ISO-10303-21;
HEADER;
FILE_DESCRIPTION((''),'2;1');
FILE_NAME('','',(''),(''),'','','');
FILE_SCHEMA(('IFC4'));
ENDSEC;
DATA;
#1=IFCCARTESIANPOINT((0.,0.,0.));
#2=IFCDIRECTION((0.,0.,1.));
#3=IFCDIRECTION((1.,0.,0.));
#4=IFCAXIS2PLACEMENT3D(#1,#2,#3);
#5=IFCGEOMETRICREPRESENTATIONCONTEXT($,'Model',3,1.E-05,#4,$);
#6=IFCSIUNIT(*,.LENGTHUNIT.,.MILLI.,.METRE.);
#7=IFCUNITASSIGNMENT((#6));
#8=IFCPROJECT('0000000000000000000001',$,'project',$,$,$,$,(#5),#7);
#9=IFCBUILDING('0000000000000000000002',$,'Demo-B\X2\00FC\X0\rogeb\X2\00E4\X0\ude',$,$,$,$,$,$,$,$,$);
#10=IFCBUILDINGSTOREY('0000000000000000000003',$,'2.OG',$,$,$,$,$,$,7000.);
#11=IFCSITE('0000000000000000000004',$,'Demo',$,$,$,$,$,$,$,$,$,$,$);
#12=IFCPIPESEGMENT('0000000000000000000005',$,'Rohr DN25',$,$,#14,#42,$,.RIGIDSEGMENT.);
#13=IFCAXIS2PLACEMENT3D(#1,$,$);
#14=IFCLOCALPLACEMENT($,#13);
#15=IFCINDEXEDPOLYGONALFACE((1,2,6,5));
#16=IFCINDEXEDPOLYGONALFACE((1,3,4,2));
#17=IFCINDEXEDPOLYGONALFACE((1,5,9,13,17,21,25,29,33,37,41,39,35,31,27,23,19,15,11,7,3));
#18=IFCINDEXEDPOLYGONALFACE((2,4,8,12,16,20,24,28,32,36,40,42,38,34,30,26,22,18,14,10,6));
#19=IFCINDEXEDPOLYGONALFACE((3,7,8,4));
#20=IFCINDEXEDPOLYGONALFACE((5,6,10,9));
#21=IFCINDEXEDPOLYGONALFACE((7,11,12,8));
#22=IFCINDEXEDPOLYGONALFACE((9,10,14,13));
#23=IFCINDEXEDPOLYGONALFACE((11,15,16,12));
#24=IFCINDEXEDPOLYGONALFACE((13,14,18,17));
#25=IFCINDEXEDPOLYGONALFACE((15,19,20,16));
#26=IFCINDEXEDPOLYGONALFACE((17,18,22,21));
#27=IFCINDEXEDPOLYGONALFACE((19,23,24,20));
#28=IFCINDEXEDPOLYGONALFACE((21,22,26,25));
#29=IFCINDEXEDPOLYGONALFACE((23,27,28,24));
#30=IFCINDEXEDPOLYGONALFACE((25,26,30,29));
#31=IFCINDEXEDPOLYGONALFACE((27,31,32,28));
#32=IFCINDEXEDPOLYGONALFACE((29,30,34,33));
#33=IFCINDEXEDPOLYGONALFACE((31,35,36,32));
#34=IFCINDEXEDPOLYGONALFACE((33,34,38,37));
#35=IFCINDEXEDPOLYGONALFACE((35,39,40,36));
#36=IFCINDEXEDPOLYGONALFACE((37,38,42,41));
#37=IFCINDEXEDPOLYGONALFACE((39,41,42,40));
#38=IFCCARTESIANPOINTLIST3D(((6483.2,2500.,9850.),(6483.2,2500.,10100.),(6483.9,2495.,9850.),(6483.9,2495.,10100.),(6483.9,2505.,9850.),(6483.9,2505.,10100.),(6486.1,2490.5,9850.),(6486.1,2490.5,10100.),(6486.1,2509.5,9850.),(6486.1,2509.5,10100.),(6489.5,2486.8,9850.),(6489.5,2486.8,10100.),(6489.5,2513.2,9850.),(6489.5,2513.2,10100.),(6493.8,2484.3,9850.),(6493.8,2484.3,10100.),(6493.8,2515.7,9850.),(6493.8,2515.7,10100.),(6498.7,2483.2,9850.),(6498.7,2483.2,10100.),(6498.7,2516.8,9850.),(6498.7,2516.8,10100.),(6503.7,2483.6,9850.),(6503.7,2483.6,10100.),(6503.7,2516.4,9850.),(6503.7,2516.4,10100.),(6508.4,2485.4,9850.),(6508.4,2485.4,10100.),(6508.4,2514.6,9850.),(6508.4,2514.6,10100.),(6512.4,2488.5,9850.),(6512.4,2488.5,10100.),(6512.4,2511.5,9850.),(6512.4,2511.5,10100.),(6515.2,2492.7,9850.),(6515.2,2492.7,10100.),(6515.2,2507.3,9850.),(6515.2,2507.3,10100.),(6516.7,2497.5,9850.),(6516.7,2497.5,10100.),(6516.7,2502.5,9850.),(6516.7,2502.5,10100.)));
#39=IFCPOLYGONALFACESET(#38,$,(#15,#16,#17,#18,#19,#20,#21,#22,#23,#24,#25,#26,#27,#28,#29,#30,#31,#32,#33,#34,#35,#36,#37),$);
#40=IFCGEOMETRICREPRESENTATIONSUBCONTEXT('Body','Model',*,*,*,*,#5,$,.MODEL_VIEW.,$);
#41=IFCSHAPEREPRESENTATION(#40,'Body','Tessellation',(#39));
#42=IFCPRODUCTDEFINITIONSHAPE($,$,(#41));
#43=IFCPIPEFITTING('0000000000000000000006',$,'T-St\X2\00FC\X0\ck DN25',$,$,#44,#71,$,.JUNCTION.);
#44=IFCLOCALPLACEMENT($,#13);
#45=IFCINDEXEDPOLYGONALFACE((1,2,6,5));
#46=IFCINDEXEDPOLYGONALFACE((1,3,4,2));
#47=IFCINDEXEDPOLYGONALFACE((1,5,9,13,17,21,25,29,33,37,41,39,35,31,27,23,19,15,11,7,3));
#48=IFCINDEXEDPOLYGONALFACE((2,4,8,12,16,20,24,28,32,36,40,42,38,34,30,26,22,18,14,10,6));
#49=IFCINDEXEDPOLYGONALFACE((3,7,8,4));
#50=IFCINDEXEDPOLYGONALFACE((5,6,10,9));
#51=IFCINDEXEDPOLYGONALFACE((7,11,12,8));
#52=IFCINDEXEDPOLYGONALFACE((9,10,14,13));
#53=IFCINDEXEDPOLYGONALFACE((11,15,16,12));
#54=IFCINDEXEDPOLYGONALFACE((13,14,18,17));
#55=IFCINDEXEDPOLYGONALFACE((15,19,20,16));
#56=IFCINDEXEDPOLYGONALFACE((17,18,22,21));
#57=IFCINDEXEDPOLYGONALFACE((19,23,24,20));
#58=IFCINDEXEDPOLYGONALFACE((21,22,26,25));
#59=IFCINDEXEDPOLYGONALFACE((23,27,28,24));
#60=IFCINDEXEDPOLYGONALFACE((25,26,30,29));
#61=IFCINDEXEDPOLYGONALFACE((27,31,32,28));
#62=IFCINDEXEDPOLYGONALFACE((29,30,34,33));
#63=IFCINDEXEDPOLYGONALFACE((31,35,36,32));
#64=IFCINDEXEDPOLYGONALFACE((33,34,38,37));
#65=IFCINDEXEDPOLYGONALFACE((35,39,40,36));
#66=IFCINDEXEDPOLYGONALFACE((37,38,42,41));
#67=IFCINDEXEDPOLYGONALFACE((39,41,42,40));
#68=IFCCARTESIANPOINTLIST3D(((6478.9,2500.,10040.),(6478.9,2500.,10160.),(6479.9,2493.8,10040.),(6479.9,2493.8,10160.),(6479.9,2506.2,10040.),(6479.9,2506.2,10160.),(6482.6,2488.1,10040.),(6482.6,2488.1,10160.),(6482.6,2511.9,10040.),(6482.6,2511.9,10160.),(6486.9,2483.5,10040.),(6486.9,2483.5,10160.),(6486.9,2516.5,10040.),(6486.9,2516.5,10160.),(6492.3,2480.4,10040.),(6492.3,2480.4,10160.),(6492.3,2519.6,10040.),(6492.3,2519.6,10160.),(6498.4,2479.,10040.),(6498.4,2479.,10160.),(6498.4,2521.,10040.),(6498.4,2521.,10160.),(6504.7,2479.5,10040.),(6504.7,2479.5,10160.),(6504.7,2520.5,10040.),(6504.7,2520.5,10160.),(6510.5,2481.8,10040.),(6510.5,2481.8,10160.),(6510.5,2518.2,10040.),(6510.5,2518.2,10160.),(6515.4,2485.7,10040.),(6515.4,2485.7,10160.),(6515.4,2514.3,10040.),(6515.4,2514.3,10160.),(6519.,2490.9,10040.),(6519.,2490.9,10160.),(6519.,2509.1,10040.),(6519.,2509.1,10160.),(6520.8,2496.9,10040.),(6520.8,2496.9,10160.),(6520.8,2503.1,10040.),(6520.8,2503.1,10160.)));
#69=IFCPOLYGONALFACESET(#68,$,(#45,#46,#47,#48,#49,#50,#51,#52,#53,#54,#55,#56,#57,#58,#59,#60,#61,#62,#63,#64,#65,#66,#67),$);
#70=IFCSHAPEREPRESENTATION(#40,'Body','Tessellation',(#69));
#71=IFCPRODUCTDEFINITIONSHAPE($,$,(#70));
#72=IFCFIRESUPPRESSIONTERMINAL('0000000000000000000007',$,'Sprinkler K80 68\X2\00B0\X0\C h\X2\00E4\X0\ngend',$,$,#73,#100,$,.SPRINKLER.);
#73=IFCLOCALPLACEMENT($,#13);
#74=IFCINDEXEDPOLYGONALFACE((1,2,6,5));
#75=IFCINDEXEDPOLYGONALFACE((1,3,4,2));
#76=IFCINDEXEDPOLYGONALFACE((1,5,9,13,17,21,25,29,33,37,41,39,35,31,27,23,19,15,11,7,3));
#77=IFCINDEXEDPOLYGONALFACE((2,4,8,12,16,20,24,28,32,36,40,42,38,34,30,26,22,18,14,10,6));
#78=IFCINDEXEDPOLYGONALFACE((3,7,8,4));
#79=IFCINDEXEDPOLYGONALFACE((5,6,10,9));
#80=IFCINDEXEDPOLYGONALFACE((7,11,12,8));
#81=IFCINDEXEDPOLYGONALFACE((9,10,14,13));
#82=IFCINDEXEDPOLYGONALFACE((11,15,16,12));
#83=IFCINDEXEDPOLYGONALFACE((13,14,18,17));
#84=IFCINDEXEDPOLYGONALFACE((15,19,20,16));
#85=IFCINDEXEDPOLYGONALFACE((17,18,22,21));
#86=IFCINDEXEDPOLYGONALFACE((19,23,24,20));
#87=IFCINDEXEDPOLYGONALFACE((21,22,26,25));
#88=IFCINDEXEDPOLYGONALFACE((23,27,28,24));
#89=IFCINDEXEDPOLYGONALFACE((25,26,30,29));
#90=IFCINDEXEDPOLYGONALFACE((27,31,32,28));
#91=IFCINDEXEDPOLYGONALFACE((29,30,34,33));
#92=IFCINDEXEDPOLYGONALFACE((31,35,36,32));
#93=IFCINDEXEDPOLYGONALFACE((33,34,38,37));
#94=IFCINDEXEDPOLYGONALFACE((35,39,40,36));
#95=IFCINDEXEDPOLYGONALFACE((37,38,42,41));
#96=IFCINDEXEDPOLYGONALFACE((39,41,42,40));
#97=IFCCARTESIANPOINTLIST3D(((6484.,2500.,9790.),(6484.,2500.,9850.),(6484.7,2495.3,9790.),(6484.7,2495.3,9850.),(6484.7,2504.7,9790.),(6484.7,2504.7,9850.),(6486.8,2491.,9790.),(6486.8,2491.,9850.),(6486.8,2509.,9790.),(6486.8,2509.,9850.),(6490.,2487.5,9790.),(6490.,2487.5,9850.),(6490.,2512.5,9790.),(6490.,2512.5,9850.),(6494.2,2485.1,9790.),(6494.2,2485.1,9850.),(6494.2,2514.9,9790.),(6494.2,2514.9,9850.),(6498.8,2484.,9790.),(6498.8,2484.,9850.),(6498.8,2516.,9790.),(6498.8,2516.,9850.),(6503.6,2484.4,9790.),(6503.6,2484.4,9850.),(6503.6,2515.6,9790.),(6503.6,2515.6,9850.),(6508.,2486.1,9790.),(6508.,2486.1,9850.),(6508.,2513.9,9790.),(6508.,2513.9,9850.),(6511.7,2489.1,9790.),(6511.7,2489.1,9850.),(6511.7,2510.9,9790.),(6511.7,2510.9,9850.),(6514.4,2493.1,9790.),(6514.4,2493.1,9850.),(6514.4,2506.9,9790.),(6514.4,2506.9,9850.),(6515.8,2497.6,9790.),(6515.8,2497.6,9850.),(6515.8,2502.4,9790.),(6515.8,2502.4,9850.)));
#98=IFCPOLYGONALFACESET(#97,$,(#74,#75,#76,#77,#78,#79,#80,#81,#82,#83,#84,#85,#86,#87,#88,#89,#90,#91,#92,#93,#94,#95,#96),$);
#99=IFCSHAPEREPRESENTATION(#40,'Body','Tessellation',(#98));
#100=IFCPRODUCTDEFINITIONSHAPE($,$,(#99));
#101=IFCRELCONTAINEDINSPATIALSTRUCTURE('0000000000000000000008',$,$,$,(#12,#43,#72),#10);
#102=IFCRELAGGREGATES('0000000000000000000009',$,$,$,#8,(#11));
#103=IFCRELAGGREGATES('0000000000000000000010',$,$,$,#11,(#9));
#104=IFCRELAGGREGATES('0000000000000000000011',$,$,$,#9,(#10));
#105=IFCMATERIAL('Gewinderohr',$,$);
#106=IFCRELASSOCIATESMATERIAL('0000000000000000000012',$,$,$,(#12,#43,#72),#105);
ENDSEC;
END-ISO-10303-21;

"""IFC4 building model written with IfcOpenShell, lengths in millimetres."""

from ifc_helpers import new_model, si_unit, frame, origin_with_axes, place, context, subcontext, project, spatial, circle, extrude, material, element, save


model = new_model("IFC4")

# Units and contexts
model_context = context("Model", 3, precision=1e-05, world=origin_with_axes())
body_context = subcontext(model_context, "Body", "Model", "MODEL_VIEW")
ifc_project = project(units=[si_unit("LENGTHUNIT", "METRE", prefix="MILLI")], contexts=[model_context])

# Site, building, storey
site = spatial("IfcSite", under=ifc_project, Name="Demo")
building = spatial("IfcBuilding", under=site, Name="Demo-Bürogebäude")
storey = spatial("IfcBuildingStorey", under=building, Name="2.OG", Elevation=7000.0)

# Shared definitions
ifc_material_1 = material(Name="Gewinderohr")

# Pipe segment
pipe_segment_1_placement = place(None, frame((6500.0, 2500.0, 10100.0), z_axis=(0.0, 0.0, -1.0), x_axis=(-1.0, 0.0, 0.0)))
element("IfcPipeSegment", 1, at=pipe_segment_1_placement, inside=storey, material=ifc_material_1, Name="Rohr DN25", PredefinedType="RIGIDSEGMENT", context=body_context, shape_type="SweptSolid", body=[
    extrude(circle(Radius=16.9), origin_with_axes(), (0.0, 0.0, 1.0), 250.0),
])

# Pipe fitting
pipe_fitting_1_placement = place(None, frame((6500.0, 2500.0, 10160.0), z_axis=(0.0, 0.0, -1.0), x_axis=(-1.0, 0.0, 0.0)))
element("IfcPipeFitting", 2, at=pipe_fitting_1_placement, inside=storey, material=ifc_material_1, Name="T-Stück DN25", PredefinedType="JUNCTION", context=body_context, shape_type="SweptSolid", body=[
    extrude(circle(Radius=21.1), origin_with_axes(), (0.0, 0.0, 1.0), 120.0),
])

# Fire suppression terminal
fire_suppression_terminal_1_placement = place(None, frame((6500.0, 2500.0, 9850.0), z_axis=(0.0, 0.0, -1.0), x_axis=(-1.0, 0.0, 0.0)))
element("IfcFireSuppressionTerminal", 3, at=fire_suppression_terminal_1_placement, inside=storey, material=ifc_material_1, Name="Sprinkler K80 68°C hängend", PredefinedType="SPRINKLER", context=body_context, shape_type="SweptSolid", body=[
    extrude(circle(Radius=16.0), origin_with_axes(), (0.0, 0.0, 1.0), 60.0),
])

save(model, "model.ifc")
